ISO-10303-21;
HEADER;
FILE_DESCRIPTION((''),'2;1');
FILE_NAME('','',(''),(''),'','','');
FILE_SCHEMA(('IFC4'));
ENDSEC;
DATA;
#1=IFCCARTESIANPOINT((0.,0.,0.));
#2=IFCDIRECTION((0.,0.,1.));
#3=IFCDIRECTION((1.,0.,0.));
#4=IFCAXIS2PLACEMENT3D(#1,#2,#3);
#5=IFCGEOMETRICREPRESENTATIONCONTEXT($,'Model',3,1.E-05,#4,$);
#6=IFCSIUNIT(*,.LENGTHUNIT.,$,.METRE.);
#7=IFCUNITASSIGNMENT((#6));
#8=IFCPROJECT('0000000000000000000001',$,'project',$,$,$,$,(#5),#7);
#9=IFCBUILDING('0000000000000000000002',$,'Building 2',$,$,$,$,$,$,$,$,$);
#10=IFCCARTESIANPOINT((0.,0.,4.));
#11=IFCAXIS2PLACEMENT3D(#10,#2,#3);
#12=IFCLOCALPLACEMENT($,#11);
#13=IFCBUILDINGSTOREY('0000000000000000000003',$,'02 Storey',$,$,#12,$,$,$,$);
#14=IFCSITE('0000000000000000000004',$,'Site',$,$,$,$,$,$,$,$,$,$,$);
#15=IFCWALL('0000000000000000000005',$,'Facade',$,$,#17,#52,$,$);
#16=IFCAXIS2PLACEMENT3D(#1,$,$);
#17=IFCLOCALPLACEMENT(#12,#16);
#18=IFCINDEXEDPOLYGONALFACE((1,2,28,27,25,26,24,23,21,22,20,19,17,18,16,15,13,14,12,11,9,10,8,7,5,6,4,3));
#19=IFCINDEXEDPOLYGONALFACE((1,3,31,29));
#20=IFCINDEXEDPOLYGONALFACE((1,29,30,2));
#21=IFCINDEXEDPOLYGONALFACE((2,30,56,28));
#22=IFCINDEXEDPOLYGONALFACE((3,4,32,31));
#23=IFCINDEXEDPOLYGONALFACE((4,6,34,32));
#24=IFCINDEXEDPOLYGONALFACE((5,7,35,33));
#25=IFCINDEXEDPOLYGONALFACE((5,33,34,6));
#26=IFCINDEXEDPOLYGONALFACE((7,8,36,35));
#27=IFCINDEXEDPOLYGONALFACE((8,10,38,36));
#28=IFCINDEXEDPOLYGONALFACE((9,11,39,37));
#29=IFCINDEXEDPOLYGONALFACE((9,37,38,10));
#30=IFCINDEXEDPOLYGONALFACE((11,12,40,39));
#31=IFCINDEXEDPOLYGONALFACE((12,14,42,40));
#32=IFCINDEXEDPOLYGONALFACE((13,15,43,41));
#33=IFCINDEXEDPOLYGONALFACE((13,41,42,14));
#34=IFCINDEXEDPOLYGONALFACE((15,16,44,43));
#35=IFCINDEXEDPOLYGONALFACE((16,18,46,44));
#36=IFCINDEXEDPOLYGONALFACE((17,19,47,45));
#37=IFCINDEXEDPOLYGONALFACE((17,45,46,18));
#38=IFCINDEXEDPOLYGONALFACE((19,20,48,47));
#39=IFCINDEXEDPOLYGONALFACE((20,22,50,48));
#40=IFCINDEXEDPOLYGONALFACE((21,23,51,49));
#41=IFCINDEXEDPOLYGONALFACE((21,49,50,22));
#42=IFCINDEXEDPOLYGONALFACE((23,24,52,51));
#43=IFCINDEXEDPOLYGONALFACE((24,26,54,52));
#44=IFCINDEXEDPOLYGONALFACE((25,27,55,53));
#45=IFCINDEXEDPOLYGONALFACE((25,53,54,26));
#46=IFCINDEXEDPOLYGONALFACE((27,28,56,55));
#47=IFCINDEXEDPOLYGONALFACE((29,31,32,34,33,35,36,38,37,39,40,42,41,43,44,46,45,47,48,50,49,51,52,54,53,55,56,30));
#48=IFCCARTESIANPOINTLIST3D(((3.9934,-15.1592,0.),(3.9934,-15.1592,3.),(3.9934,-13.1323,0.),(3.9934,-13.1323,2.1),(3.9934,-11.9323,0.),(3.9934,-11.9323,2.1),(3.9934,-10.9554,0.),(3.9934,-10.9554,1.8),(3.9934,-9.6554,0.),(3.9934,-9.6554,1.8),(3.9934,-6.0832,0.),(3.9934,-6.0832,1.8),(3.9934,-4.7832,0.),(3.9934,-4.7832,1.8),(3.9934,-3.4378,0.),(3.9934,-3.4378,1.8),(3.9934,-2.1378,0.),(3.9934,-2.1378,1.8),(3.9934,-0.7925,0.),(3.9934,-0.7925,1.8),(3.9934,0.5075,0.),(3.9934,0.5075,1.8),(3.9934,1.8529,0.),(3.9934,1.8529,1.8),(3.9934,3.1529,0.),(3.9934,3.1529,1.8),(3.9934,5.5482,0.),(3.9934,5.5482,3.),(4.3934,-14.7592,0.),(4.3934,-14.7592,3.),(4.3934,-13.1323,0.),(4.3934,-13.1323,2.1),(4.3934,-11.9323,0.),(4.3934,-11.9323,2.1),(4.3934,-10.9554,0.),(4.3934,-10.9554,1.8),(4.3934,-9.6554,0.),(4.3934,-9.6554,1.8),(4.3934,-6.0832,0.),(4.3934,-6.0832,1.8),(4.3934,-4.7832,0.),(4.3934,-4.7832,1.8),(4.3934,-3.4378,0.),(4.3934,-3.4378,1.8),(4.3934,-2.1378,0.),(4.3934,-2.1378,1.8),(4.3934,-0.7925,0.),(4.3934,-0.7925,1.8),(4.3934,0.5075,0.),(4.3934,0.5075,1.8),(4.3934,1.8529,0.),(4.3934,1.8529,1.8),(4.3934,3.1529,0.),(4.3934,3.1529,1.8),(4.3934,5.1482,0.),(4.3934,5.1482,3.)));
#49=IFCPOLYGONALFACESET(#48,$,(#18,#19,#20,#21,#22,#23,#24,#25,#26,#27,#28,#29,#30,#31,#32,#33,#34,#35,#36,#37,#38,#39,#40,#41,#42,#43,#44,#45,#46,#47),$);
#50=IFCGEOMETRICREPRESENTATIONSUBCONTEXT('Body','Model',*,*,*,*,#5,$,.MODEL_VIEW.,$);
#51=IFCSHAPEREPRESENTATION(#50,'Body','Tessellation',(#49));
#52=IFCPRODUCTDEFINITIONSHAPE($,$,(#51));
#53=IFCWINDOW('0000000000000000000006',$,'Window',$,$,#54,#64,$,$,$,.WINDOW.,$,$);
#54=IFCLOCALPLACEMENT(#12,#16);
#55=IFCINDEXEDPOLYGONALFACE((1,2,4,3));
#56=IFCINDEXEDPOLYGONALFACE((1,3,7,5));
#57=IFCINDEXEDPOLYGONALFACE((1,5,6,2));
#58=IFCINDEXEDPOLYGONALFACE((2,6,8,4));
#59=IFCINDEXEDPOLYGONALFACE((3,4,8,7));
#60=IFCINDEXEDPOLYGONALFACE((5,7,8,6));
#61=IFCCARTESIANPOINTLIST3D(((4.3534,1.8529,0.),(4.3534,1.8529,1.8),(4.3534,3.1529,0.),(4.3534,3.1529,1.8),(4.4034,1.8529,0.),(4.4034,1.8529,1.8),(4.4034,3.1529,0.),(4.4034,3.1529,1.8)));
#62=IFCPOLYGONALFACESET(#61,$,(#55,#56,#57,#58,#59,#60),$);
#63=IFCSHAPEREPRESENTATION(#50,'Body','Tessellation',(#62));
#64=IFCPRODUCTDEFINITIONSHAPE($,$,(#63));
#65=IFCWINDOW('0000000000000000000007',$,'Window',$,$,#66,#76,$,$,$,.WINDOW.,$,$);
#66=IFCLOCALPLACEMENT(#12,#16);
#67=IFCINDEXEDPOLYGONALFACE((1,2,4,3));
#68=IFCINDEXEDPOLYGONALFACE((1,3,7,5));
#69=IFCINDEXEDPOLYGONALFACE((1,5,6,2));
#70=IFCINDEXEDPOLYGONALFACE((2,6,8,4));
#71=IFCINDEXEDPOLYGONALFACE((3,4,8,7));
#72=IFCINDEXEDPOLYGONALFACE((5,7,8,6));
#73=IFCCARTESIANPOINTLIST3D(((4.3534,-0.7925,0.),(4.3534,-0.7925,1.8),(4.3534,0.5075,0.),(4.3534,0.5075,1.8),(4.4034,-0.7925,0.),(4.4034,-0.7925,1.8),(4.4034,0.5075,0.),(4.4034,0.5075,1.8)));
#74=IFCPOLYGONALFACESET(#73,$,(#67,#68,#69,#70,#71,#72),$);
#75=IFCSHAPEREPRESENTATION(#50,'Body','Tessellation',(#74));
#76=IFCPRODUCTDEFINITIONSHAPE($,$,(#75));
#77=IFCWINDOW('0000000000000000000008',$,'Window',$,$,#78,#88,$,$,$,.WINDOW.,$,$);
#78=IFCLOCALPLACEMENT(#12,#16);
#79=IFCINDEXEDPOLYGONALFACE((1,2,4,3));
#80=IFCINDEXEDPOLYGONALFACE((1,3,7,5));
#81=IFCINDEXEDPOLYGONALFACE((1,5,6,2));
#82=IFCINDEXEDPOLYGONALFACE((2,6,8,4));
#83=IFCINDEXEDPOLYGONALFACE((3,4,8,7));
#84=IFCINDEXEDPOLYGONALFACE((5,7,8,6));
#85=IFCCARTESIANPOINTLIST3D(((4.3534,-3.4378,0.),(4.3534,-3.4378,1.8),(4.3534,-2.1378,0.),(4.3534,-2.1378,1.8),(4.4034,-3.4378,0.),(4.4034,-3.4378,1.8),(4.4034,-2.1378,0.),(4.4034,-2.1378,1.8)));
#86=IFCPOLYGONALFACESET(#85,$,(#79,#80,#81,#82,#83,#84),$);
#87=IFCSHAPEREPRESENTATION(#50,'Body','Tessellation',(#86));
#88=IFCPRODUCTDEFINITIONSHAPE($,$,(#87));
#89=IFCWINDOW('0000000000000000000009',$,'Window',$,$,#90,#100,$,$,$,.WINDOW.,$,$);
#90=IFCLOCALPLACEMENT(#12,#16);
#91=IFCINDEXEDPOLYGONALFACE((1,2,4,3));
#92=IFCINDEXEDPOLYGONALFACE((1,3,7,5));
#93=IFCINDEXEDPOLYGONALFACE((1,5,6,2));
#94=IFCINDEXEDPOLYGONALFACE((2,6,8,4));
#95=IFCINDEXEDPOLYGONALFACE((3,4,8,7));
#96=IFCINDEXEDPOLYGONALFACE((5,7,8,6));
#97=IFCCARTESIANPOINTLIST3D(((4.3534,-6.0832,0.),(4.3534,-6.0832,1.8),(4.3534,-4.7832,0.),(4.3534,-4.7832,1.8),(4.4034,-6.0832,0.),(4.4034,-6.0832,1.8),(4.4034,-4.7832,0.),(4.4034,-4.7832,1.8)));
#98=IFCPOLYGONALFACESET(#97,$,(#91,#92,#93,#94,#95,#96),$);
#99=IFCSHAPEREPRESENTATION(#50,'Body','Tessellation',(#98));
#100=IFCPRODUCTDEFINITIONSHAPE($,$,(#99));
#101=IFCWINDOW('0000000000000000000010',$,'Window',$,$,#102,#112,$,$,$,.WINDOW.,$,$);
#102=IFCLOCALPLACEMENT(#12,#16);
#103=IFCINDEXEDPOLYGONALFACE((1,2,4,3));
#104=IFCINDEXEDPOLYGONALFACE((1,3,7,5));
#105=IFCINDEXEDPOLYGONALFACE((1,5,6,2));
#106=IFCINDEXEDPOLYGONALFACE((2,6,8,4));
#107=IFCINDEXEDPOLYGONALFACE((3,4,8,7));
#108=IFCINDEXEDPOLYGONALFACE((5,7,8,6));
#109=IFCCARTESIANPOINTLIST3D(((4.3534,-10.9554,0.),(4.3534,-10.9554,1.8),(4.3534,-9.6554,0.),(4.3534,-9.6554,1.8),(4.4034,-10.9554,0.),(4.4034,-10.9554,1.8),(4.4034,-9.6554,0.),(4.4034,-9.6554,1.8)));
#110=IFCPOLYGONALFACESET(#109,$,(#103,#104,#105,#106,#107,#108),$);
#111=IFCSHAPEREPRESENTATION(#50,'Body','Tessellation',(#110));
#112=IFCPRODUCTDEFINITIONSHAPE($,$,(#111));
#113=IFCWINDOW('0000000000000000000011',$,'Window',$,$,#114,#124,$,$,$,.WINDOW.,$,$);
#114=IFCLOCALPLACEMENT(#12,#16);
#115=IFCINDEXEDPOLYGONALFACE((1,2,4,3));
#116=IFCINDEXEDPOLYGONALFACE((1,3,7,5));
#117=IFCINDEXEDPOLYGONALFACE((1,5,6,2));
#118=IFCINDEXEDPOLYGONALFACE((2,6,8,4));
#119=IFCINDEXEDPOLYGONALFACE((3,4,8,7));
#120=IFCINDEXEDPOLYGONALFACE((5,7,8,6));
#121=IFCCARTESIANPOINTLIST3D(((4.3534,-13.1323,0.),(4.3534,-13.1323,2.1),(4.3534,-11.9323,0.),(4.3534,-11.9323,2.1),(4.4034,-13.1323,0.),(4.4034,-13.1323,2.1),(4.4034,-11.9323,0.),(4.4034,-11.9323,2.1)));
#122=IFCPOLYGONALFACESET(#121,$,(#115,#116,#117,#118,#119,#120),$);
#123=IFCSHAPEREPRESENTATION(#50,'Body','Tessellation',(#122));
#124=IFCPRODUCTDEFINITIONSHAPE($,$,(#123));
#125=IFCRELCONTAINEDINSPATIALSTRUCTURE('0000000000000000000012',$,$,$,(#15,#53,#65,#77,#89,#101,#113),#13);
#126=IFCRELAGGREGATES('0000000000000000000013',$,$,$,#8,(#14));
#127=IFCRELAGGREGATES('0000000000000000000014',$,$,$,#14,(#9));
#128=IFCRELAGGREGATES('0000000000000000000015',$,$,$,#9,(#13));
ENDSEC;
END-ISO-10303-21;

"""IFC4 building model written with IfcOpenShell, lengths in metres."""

from ifc_helpers import new_model, si_unit, frame, origin_with_axes, place, context, subcontext, project, spatial, line, indexed_curve, outline, extrude, element, fill, save


model = new_model("IFC4")

# Units and contexts
model_context = context("Model", 3, precision=1e-05, world=origin_with_axes())
body_context = subcontext(model_context, "Body", "Model", "MODEL_VIEW")
ifc_project = project(units=[si_unit("LENGTHUNIT", "METRE")], contexts=[model_context])

# Site, building, storey
site = spatial("IfcSite", under=ifc_project, Name="Site")
building = spatial("IfcBuilding", under=site, Name="Building 2")
storey_placement = place(None, frame((0.0, 0.0, 4.0), z_axis=(0.0, 0.0, 1.0), x_axis=(1.0, 0.0, 0.0)))
storey = spatial("IfcBuildingStorey", under=building, at=storey_placement, Name="02 Storey")

# Wall, openings, windows
wall_1_placement = place(storey_placement, origin_with_axes())
wall_1 = element("IfcWall", 1, at=wall_1_placement, inside=storey, Name="Facade", context=body_context, shape_type="SweptSolid", body=[
    extrude(outline(indexed_curve([(4.3934, 5.1482), (4.3934, -14.7592), (3.9934, -15.1592), (3.9934, 5.5482)], segments=[line(1, 2), line(2, 3), line(3, 4)])), origin_with_axes(), (0.0, 0.0, 1.0), 3.0),
])
opening_1_placement = place(wall_1_placement, origin_with_axes())
opening_1 = element("IfcOpeningElement", 2, at=opening_1_placement, cuts=wall_1, context=body_context, shape_type="SweptSolid", body=[
    extrude(outline(indexed_curve([(3.9534, 3.1529), (4.4534, 3.1529), (4.4534, 1.8529), (3.9534, 1.8529)], segments=[line(1, 2), line(2, 3), line(3, 4)])), origin_with_axes(), (0.0, 0.0, 1.0), 1.8),
])
opening_2_placement = place(wall_1_placement, origin_with_axes())
opening_2 = element("IfcOpeningElement", 3, at=opening_2_placement, cuts=wall_1, context=body_context, shape_type="SweptSolid", body=[
    extrude(outline(indexed_curve([(3.9534, 0.5075), (4.4534, 0.5075), (4.4534, -0.7925), (3.9534, -0.7925)], segments=[line(1, 2), line(2, 3), line(3, 4)])), origin_with_axes(), (0.0, 0.0, 1.0), 1.8),
])
opening_3_placement = place(wall_1_placement, origin_with_axes())
opening_3 = element("IfcOpeningElement", 4, at=opening_3_placement, cuts=wall_1, context=body_context, shape_type="SweptSolid", body=[
    extrude(outline(indexed_curve([(3.9534, -2.1378), (4.4534, -2.1378), (4.4534, -3.4378), (3.9534, -3.4378)], segments=[line(1, 2), line(2, 3), line(3, 4)])), origin_with_axes(), (0.0, 0.0, 1.0), 1.8),
])
opening_4_placement = place(wall_1_placement, origin_with_axes())
opening_4 = element("IfcOpeningElement", 5, at=opening_4_placement, cuts=wall_1, context=body_context, shape_type="SweptSolid", body=[
    extrude(outline(indexed_curve([(3.9534, -4.7832), (4.4534, -4.7832), (4.4534, -6.0832), (3.9534, -6.0832)], segments=[line(1, 2), line(2, 3), line(3, 4)])), origin_with_axes(), (0.0, 0.0, 1.0), 1.8),
])
opening_5_placement = place(wall_1_placement, origin_with_axes())
opening_5 = element("IfcOpeningElement", 6, at=opening_5_placement, cuts=wall_1, context=body_context, shape_type="SweptSolid", body=[
    extrude(outline(indexed_curve([(3.9534, -9.6554), (4.4534, -9.6554), (4.4534, -10.9554), (3.9534, -10.9554)], segments=[line(1, 2), line(2, 3), line(3, 4)])), origin_with_axes(), (0.0, 0.0, 1.0), 1.8),
])
opening_6_placement = place(wall_1_placement, origin_with_axes())
opening_6 = element("IfcOpeningElement", 7, at=opening_6_placement, cuts=wall_1, context=body_context, shape_type="SweptSolid", body=[
    extrude(outline(indexed_curve([(3.9534, -11.9323), (4.4534, -11.9323), (4.4534, -13.1323), (3.9534, -13.1323)], segments=[line(1, 2), line(2, 3), line(3, 4)])), origin_with_axes(), (0.0, 0.0, 1.0), 2.1),
])
window_1_placement = place(storey_placement, origin_with_axes())
window_1 = element("IfcWindow", 8, at=window_1_placement, inside=storey, Name="Window", PredefinedType="WINDOW", context=body_context, shape_type="SweptSolid", body=[
    extrude(outline(indexed_curve([(4.3534, 3.1529), (4.4034, 3.1529), (4.4034, 1.8529), (4.3534, 1.8529)], segments=[line(1, 2), line(2, 3), line(3, 4)])), origin_with_axes(), (0.0, 0.0, 1.0), 1.8),
])
fill(opening_1, window_1)
window_2_placement = place(storey_placement, origin_with_axes())
window_2 = element("IfcWindow", 9, at=window_2_placement, inside=storey, Name="Window", PredefinedType="WINDOW", context=body_context, shape_type="SweptSolid", body=[
    extrude(outline(indexed_curve([(4.3534, 0.5075), (4.4034, 0.5075), (4.4034, -0.7925), (4.3534, -0.7925)], segments=[line(1, 2), line(2, 3), line(3, 4)])), origin_with_axes(), (0.0, 0.0, 1.0), 1.8),
])
fill(opening_2, window_2)
window_3_placement = place(storey_placement, origin_with_axes())
window_3 = element("IfcWindow", 10, at=window_3_placement, inside=storey, Name="Window", PredefinedType="WINDOW", context=body_context, shape_type="SweptSolid", body=[
    extrude(outline(indexed_curve([(4.3534, -2.1378), (4.4034, -2.1378), (4.4034, -3.4378), (4.3534, -3.4378)], segments=[line(1, 2), line(2, 3), line(3, 4)])), origin_with_axes(), (0.0, 0.0, 1.0), 1.8),
])
fill(opening_3, window_3)
window_4_placement = place(storey_placement, origin_with_axes())
window_4 = element("IfcWindow", 11, at=window_4_placement, inside=storey, Name="Window", PredefinedType="WINDOW", context=body_context, shape_type="SweptSolid", body=[
    extrude(outline(indexed_curve([(4.3534, -4.7832), (4.4034, -4.7832), (4.4034, -6.0832), (4.3534, -6.0832)], segments=[line(1, 2), line(2, 3), line(3, 4)])), origin_with_axes(), (0.0, 0.0, 1.0), 1.8),
])
fill(opening_4, window_4)
window_5_placement = place(storey_placement, origin_with_axes())
window_5 = element("IfcWindow", 12, at=window_5_placement, inside=storey, Name="Window", PredefinedType="WINDOW", context=body_context, shape_type="SweptSolid", body=[
    extrude(outline(indexed_curve([(4.3534, -9.6554), (4.4034, -9.6554), (4.4034, -10.9554), (4.3534, -10.9554)], segments=[line(1, 2), line(2, 3), line(3, 4)])), origin_with_axes(), (0.0, 0.0, 1.0), 1.8),
])
fill(opening_5, window_5)
window_6_placement = place(storey_placement, origin_with_axes())
window_6 = element("IfcWindow", 13, at=window_6_placement, inside=storey, Name="Window", PredefinedType="WINDOW", context=body_context, shape_type="SweptSolid", body=[
    extrude(outline(indexed_curve([(4.3534, -11.9323), (4.4034, -11.9323), (4.4034, -13.1323), (4.3534, -13.1323)], segments=[line(1, 2), line(2, 3), line(3, 4)])), origin_with_axes(), (0.0, 0.0, 1.0), 2.1),
])
fill(opening_6, window_6)

save(model, "model.ifc")
